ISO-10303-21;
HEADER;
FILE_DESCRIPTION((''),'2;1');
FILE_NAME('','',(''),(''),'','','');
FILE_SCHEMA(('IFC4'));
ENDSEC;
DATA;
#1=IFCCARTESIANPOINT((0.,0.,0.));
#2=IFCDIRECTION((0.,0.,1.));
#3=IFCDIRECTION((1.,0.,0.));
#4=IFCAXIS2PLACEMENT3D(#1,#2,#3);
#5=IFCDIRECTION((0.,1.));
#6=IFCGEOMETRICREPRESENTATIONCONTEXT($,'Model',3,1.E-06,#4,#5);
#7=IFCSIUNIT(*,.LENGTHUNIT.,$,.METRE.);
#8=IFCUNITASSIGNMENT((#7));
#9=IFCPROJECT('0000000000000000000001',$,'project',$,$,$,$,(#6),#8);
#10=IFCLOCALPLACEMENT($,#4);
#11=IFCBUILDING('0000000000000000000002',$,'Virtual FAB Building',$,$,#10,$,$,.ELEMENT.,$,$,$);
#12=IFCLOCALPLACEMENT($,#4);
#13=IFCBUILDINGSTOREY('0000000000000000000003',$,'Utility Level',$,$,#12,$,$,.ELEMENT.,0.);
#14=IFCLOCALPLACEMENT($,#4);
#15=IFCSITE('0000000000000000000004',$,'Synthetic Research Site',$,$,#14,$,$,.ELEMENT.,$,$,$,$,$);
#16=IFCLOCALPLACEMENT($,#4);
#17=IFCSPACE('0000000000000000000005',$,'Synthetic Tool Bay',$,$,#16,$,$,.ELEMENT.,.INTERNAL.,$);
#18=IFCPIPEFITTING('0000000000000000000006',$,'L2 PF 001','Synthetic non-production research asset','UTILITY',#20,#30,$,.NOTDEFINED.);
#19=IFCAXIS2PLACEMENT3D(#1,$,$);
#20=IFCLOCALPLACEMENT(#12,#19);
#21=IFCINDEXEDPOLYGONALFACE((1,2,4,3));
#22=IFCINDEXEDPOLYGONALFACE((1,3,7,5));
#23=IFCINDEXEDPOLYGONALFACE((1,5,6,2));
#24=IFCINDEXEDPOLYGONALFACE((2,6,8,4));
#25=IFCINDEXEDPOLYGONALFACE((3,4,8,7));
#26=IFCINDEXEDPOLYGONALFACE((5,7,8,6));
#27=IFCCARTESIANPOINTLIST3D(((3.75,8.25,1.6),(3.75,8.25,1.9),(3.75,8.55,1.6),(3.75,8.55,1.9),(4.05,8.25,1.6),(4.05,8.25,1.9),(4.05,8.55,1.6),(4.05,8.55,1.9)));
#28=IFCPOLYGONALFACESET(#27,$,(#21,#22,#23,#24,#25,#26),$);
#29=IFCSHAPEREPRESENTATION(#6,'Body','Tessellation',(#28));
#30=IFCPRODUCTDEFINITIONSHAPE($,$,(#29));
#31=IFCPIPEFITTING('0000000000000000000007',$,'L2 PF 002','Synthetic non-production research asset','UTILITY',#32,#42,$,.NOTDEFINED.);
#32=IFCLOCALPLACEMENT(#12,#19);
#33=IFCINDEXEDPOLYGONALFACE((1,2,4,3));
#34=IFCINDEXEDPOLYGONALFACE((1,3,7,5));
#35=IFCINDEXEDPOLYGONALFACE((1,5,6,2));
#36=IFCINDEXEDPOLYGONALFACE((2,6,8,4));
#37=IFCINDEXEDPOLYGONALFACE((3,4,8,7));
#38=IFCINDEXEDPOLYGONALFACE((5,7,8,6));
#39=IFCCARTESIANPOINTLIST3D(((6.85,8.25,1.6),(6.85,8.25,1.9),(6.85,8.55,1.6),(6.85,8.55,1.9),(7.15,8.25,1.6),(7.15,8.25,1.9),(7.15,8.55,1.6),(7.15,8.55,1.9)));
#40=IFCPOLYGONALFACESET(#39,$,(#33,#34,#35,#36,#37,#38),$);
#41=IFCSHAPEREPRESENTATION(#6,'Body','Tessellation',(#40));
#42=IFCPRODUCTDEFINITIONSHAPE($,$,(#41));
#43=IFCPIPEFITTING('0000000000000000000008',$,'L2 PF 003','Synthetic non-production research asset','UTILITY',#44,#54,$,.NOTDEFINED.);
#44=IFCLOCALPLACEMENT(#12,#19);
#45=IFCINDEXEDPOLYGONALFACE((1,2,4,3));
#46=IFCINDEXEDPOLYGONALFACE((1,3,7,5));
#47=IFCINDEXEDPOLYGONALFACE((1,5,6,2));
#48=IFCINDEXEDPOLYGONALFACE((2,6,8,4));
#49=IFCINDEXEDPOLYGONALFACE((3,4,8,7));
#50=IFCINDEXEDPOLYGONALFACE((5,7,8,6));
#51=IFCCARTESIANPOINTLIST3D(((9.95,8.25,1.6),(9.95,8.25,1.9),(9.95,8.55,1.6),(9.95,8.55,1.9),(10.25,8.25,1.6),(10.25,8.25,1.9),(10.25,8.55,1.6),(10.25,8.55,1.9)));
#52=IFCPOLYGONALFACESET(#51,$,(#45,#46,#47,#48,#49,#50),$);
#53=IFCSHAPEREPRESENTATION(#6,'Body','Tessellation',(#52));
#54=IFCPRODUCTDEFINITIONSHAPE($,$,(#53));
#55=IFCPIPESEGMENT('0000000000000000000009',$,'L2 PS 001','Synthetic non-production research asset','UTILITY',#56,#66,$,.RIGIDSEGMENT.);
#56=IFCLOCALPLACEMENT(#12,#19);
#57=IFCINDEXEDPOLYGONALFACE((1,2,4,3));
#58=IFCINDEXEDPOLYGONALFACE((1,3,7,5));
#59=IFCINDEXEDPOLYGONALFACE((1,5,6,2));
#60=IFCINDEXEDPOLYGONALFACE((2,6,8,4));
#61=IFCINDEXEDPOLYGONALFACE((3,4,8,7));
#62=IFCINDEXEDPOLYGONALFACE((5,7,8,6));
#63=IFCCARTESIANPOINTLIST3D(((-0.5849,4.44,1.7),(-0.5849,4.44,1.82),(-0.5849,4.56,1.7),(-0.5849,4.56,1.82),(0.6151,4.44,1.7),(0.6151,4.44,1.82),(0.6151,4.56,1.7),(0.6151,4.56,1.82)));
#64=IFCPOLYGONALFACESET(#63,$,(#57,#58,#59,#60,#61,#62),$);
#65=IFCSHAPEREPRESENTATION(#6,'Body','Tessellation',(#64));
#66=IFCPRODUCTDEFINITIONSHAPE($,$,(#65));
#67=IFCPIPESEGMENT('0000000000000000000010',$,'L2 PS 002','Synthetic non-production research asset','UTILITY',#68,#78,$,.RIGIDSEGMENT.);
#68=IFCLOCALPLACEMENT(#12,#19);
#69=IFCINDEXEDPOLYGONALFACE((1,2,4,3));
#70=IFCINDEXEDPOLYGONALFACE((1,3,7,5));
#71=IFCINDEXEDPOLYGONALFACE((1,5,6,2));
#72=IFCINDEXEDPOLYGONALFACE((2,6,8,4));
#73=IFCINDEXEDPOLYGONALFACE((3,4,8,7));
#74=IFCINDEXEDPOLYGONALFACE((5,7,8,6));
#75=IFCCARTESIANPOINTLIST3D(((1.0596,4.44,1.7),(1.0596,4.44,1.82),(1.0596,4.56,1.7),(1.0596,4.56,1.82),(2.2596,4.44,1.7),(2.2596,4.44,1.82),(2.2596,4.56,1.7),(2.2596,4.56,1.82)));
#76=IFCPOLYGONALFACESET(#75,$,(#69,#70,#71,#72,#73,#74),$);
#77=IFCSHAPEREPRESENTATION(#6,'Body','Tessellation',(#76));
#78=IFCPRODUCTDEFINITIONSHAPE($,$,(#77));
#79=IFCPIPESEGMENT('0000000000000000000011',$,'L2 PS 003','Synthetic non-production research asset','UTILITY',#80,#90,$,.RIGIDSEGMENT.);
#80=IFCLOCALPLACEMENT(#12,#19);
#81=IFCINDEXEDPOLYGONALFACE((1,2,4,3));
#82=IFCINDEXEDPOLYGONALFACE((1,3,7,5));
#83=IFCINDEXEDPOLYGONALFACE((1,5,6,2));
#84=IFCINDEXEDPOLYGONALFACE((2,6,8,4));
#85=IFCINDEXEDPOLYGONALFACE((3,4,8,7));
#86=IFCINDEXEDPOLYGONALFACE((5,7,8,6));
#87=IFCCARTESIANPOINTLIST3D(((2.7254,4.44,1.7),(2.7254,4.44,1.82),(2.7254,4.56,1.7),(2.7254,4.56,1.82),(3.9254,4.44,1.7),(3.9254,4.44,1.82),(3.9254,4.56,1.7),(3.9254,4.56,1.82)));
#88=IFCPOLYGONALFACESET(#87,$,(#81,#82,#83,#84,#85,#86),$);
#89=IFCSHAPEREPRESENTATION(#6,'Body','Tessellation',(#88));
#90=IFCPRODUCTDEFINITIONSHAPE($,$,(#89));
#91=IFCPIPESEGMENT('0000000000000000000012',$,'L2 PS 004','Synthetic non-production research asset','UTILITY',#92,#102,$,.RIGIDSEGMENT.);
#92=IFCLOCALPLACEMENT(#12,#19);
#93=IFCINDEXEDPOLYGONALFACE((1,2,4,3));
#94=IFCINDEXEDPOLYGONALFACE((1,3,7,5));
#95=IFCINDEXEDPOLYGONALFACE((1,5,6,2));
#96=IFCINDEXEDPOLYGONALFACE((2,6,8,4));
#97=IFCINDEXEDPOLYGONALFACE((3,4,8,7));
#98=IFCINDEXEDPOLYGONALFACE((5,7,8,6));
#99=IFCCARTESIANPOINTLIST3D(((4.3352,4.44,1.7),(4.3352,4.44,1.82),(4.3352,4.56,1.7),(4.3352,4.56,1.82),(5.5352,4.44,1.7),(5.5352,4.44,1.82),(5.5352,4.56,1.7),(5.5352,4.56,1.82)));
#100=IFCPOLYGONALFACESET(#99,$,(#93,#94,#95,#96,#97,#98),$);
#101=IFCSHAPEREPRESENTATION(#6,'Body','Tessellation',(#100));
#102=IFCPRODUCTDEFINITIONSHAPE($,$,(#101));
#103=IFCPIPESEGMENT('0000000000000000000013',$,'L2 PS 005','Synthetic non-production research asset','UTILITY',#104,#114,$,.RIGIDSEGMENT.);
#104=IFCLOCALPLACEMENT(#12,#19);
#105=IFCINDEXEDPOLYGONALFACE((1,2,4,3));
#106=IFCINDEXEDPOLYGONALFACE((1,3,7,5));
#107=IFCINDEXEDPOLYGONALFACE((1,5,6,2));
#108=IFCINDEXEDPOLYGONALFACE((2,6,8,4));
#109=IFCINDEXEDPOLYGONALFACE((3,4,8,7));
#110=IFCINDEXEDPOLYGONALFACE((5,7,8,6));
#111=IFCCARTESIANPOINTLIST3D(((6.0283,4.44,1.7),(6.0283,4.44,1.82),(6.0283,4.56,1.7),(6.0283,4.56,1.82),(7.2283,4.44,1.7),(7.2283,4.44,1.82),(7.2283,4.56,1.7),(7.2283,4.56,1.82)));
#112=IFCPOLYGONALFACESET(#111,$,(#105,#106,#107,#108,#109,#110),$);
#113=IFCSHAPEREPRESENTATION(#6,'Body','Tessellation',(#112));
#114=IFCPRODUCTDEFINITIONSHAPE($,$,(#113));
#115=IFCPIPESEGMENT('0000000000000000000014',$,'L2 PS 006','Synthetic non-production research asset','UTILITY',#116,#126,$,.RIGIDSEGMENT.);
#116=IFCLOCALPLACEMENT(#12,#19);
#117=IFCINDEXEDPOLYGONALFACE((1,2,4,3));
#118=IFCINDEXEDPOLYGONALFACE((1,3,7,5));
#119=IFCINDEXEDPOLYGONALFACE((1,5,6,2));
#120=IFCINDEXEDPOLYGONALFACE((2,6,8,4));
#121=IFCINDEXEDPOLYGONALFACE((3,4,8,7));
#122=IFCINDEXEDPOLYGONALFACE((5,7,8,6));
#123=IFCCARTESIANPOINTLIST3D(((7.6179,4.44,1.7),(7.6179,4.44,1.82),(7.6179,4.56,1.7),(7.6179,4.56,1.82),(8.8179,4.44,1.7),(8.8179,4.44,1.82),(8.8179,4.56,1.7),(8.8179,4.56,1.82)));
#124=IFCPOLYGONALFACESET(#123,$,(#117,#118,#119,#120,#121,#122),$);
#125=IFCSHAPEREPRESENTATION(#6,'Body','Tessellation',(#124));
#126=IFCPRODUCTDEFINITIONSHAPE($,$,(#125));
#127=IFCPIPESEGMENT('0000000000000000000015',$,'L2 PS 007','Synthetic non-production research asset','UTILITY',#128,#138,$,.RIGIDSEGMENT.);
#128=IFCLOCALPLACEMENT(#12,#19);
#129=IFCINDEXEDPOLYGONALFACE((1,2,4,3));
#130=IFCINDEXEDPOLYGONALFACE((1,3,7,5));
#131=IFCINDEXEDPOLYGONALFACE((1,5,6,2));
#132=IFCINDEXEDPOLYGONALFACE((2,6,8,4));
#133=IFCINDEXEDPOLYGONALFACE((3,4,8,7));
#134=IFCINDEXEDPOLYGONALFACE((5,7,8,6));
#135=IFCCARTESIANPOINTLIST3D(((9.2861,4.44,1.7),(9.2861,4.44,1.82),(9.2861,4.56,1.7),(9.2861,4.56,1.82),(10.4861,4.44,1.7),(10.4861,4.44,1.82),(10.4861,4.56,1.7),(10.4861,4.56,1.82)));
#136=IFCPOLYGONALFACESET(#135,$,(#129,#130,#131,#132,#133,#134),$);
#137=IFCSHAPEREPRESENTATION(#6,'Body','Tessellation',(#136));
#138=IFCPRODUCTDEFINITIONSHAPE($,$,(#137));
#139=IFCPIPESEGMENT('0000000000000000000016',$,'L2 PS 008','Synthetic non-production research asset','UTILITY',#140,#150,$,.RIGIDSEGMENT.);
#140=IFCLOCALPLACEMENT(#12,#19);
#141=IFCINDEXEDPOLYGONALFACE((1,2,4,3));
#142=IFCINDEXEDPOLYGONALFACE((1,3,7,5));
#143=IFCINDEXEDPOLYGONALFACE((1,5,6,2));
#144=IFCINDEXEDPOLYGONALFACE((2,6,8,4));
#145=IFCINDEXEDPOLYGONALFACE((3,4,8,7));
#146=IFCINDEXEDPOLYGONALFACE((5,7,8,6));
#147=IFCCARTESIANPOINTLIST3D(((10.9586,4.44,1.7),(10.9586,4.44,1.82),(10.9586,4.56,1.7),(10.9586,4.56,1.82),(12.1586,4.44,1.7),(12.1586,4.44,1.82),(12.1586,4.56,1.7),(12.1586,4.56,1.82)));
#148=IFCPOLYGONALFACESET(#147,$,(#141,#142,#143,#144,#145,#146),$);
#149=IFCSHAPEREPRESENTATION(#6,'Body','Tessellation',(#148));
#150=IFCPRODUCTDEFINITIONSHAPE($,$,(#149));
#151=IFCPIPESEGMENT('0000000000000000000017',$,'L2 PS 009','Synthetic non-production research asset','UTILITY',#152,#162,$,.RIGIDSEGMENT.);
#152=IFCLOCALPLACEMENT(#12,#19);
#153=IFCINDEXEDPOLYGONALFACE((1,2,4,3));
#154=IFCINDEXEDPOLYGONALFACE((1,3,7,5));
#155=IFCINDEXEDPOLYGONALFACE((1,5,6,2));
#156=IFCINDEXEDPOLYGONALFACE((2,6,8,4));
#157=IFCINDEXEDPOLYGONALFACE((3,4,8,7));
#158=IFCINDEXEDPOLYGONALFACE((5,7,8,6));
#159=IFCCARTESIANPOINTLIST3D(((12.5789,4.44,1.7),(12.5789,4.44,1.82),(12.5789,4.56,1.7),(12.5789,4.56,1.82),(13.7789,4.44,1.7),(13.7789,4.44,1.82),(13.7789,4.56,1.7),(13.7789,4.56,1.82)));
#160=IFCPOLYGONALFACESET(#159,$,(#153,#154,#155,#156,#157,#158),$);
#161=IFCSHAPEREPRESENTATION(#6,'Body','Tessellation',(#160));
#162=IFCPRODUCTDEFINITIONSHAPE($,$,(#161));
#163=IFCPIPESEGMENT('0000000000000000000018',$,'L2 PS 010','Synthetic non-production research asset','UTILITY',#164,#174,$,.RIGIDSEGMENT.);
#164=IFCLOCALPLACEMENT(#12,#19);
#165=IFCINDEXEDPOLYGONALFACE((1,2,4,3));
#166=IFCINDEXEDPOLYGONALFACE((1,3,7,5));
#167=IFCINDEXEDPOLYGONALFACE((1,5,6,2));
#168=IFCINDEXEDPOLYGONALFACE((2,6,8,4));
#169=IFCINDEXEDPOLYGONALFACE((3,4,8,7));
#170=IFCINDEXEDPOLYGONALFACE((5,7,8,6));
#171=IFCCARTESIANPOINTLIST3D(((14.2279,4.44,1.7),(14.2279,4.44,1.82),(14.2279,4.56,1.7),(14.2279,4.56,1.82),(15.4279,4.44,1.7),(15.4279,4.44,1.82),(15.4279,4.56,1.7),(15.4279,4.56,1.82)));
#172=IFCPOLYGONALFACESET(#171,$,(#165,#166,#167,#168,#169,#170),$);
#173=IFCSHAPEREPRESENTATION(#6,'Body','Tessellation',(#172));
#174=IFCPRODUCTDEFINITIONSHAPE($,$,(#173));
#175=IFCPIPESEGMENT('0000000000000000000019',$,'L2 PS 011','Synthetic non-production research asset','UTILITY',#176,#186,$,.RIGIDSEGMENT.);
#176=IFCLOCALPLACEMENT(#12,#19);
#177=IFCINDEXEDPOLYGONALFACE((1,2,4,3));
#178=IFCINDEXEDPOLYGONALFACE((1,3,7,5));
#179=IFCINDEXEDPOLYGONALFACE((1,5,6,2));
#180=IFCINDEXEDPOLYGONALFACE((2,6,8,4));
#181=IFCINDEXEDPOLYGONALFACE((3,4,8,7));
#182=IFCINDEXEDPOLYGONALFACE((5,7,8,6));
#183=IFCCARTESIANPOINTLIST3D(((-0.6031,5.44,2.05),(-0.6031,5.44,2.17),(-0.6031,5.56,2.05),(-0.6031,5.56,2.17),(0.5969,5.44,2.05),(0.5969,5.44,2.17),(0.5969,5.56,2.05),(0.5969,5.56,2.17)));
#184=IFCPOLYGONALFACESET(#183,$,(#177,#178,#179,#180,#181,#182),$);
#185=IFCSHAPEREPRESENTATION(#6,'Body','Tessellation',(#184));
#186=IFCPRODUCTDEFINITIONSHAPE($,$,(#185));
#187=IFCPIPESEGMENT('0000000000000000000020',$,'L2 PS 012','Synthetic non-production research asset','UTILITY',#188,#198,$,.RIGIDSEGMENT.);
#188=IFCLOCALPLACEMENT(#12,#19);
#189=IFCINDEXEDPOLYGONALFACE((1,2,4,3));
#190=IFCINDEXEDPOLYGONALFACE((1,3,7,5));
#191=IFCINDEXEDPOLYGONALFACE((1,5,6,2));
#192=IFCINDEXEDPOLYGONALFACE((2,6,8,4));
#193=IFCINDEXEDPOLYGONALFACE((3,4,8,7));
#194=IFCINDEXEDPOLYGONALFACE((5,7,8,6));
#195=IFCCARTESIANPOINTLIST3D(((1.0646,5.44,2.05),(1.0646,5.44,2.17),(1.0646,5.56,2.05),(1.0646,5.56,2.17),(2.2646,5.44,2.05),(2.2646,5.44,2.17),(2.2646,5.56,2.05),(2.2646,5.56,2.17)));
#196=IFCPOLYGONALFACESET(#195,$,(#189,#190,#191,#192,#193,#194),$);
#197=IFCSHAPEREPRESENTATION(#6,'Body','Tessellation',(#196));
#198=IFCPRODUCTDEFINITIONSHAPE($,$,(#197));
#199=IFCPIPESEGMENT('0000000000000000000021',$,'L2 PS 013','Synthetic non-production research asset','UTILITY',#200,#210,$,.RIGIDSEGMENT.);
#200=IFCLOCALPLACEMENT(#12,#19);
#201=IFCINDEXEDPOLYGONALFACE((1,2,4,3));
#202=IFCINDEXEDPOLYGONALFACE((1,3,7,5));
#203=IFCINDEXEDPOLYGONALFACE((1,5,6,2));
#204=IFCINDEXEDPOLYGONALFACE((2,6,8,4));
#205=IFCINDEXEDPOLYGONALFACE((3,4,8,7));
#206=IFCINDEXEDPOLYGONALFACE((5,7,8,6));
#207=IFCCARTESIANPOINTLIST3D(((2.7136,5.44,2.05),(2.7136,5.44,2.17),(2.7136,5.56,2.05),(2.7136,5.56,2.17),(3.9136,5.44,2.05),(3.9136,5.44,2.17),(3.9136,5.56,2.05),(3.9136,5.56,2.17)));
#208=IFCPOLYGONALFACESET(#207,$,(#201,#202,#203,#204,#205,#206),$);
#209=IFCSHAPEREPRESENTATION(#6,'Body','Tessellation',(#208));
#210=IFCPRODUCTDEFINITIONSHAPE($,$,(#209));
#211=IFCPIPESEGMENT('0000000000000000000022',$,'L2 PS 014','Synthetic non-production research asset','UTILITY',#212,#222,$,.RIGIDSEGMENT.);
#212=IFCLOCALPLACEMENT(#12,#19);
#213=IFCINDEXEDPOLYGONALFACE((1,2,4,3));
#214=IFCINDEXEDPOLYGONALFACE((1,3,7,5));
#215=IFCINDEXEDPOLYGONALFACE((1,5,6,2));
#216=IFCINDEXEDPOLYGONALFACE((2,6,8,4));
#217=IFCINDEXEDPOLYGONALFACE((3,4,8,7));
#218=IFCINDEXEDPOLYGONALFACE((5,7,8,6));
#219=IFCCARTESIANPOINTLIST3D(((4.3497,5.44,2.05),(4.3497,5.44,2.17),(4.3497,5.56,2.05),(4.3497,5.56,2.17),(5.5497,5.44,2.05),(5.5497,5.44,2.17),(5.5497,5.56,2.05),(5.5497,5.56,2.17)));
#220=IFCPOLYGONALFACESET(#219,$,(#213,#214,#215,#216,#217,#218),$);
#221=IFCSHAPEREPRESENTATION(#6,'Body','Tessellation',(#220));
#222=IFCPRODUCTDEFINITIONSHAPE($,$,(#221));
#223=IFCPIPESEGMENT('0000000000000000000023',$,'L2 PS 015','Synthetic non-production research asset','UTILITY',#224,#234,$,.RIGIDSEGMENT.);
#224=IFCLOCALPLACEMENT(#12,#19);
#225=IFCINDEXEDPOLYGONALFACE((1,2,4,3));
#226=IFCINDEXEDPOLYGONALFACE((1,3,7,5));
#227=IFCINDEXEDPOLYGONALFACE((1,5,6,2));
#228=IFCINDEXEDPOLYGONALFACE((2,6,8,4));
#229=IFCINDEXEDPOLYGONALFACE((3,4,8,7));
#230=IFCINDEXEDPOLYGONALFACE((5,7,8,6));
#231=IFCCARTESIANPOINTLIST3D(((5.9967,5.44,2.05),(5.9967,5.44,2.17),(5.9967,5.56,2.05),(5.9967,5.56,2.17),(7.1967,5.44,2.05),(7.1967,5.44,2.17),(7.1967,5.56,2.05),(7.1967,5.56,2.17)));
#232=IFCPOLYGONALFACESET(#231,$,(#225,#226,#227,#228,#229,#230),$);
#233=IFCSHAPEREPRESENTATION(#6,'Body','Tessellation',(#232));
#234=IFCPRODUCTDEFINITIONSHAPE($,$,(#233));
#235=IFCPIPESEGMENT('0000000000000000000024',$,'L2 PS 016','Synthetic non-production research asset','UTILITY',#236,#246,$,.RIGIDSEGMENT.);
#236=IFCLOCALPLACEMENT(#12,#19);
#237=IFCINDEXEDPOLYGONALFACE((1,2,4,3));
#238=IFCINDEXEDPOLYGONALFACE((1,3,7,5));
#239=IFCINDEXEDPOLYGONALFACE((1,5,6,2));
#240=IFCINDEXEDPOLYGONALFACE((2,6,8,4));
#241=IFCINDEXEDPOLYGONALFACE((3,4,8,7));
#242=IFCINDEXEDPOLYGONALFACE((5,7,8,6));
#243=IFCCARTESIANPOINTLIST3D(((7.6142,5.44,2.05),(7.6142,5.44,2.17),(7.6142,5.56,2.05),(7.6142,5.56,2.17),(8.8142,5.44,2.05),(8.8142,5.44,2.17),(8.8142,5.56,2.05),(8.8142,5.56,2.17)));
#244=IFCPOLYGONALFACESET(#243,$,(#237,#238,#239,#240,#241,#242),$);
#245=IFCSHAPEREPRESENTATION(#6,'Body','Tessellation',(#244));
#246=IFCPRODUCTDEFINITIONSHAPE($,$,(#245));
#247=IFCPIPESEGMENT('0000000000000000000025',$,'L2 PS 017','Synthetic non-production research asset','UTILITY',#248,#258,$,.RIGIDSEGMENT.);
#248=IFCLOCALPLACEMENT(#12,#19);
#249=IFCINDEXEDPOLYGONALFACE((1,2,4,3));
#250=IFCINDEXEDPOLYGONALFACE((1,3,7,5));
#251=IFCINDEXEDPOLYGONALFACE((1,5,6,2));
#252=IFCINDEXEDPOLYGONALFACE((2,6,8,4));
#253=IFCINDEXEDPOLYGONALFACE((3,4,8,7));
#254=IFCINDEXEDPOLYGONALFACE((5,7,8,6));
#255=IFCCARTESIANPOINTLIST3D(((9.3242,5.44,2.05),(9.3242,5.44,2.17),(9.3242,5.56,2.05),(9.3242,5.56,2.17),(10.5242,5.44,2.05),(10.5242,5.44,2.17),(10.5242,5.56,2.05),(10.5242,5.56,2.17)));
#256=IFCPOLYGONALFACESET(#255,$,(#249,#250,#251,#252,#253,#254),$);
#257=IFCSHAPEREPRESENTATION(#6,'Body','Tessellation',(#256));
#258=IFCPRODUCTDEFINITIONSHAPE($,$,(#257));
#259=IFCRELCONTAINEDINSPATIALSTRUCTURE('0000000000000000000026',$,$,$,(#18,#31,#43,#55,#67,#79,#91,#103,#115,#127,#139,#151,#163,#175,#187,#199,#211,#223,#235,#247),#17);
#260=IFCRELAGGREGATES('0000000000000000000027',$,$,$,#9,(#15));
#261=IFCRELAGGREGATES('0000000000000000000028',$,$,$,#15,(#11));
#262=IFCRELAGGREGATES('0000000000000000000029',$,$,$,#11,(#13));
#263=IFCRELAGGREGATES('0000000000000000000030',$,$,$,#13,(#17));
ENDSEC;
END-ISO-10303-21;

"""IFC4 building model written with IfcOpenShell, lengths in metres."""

from ifc_helpers import new_model, si_unit, direction, frame, origin_with_axes, origin_2d_with_axis, place, context, project, spatial, rectangle, extrude, element, save


model = new_model("IFC4")

# Units and contexts
model_context = context("Model", 3, precision=1e-06, world=origin_with_axes(), true_north=direction((0.0, 1.0)))
ifc_project = project(units=[si_unit("LENGTHUNIT", "METRE")], contexts=[model_context])

# Site, building, storey, space
site_placement = place(None, origin_with_axes())
site = spatial("IfcSite", under=ifc_project, at=site_placement, Name="Synthetic Research Site", CompositionType="ELEMENT")
building_placement = place(None, origin_with_axes())
building = spatial("IfcBuilding", under=site, at=building_placement, Name="Virtual FAB Building", CompositionType="ELEMENT")
storey_placement = place(None, origin_with_axes())
storey = spatial("IfcBuildingStorey", under=building, at=storey_placement, Name="Utility Level", CompositionType="ELEMENT", Elevation=0.0)
space_placement = place(None, origin_with_axes())
space = spatial("IfcSpace", under=storey, at=space_placement, Name="Synthetic Tool Bay", CompositionType="ELEMENT", PredefinedType="INTERNAL")

# Pipe fittings
for number, where, z_axis, x_axis, name in (
    (1, (3.9, 8.4, 1.6), (0.0, 0.0, 1.0), (1.0, 0.0, 0.0), "L2 PF 001"),
    (2, (7.0, 8.4, 1.6), (0.0, 0.0, 1.0), (1.0, 0.0, 0.0), "L2 PF 002"),
    (3, (10.1, 8.4, 1.6), (0.0, 0.0, 1.0), (1.0, 0.0, 0.0), "L2 PF 003"),
):
    element("IfcPipeFitting", number, at=place(None, frame(where, z_axis=z_axis, x_axis=x_axis)), inside=space, Name=name, Description="Synthetic non-production research asset", ObjectType="UTILITY", PredefinedType="NOTDEFINED", context=model_context, shape_type="SweptSolid", body=[
        extrude(rectangle(XDim=0.3, YDim=0.3, at=origin_2d_with_axis()), origin_with_axes(), (0.0, 0.0, 1.0), 0.3),
    ])

# Pipe segments
for number, where, z_axis, x_axis, name in (
    (4, (0.0151, 4.5, 1.7), (0.0, 0.0, 1.0), (1.0, 0.0, 0.0), "L2 PS 001"),
    (5, (1.6596, 4.5, 1.7), (0.0, 0.0, 1.0), (1.0, 0.0, 0.0), "L2 PS 002"),
    (6, (3.3254, 4.5, 1.7), (0.0, 0.0, 1.0), (1.0, 0.0, 0.0), "L2 PS 003"),
    (7, (4.9352, 4.5, 1.7), (0.0, 0.0, 1.0), (1.0, 0.0, 0.0), "L2 PS 004"),
    (8, (6.6283, 4.5, 1.7), (0.0, 0.0, 1.0), (1.0, 0.0, 0.0), "L2 PS 005"),
    (9, (8.2179, 4.5, 1.7), (0.0, 0.0, 1.0), (1.0, 0.0, 0.0), "L2 PS 006"),
    (10, (9.8861, 4.5, 1.7), (0.0, 0.0, 1.0), (1.0, 0.0, 0.0), "L2 PS 007"),
    (11, (11.5586, 4.5, 1.7), (0.0, 0.0, 1.0), (1.0, 0.0, 0.0), "L2 PS 008"),
    (12, (13.1789, 4.5, 1.7), (0.0, 0.0, 1.0), (1.0, 0.0, 0.0), "L2 PS 009"),
    (13, (14.8279, 4.5, 1.7), (0.0, 0.0, 1.0), (1.0, 0.0, 0.0), "L2 PS 010"),
    (14, (-0.0031, 5.5, 2.05), (0.0, 0.0, 1.0), (1.0, 0.0, 0.0), "L2 PS 011"),
    (15, (1.6646, 5.5, 2.05), (0.0, 0.0, 1.0), (1.0, 0.0, 0.0), "L2 PS 012"),
    (16, (3.3136, 5.5, 2.05), (0.0, 0.0, 1.0), (1.0, 0.0, 0.0), "L2 PS 013"),
    (17, (4.9497, 5.5, 2.05), (0.0, 0.0, 1.0), (1.0, 0.0, 0.0), "L2 PS 014"),
    (18, (6.5967, 5.5, 2.05), (0.0, 0.0, 1.0), (1.0, 0.0, 0.0), "L2 PS 015"),
    (19, (8.2142, 5.5, 2.05), (0.0, 0.0, 1.0), (1.0, 0.0, 0.0), "L2 PS 016"),
    (20, (9.9242, 5.5, 2.05), (0.0, 0.0, 1.0), (1.0, 0.0, 0.0), "L2 PS 017"),
):
    element("IfcPipeSegment", number, at=place(None, frame(where, z_axis=z_axis, x_axis=x_axis)), inside=space, Name=name, Description="Synthetic non-production research asset", ObjectType="UTILITY", PredefinedType="RIGIDSEGMENT", context=model_context, shape_type="SweptSolid", body=[
        extrude(rectangle(XDim=1.2, YDim=0.12, at=origin_2d_with_axis()), origin_with_axes(), (0.0, 0.0, 1.0), 0.12),
    ])

save(model, "model.ifc")
